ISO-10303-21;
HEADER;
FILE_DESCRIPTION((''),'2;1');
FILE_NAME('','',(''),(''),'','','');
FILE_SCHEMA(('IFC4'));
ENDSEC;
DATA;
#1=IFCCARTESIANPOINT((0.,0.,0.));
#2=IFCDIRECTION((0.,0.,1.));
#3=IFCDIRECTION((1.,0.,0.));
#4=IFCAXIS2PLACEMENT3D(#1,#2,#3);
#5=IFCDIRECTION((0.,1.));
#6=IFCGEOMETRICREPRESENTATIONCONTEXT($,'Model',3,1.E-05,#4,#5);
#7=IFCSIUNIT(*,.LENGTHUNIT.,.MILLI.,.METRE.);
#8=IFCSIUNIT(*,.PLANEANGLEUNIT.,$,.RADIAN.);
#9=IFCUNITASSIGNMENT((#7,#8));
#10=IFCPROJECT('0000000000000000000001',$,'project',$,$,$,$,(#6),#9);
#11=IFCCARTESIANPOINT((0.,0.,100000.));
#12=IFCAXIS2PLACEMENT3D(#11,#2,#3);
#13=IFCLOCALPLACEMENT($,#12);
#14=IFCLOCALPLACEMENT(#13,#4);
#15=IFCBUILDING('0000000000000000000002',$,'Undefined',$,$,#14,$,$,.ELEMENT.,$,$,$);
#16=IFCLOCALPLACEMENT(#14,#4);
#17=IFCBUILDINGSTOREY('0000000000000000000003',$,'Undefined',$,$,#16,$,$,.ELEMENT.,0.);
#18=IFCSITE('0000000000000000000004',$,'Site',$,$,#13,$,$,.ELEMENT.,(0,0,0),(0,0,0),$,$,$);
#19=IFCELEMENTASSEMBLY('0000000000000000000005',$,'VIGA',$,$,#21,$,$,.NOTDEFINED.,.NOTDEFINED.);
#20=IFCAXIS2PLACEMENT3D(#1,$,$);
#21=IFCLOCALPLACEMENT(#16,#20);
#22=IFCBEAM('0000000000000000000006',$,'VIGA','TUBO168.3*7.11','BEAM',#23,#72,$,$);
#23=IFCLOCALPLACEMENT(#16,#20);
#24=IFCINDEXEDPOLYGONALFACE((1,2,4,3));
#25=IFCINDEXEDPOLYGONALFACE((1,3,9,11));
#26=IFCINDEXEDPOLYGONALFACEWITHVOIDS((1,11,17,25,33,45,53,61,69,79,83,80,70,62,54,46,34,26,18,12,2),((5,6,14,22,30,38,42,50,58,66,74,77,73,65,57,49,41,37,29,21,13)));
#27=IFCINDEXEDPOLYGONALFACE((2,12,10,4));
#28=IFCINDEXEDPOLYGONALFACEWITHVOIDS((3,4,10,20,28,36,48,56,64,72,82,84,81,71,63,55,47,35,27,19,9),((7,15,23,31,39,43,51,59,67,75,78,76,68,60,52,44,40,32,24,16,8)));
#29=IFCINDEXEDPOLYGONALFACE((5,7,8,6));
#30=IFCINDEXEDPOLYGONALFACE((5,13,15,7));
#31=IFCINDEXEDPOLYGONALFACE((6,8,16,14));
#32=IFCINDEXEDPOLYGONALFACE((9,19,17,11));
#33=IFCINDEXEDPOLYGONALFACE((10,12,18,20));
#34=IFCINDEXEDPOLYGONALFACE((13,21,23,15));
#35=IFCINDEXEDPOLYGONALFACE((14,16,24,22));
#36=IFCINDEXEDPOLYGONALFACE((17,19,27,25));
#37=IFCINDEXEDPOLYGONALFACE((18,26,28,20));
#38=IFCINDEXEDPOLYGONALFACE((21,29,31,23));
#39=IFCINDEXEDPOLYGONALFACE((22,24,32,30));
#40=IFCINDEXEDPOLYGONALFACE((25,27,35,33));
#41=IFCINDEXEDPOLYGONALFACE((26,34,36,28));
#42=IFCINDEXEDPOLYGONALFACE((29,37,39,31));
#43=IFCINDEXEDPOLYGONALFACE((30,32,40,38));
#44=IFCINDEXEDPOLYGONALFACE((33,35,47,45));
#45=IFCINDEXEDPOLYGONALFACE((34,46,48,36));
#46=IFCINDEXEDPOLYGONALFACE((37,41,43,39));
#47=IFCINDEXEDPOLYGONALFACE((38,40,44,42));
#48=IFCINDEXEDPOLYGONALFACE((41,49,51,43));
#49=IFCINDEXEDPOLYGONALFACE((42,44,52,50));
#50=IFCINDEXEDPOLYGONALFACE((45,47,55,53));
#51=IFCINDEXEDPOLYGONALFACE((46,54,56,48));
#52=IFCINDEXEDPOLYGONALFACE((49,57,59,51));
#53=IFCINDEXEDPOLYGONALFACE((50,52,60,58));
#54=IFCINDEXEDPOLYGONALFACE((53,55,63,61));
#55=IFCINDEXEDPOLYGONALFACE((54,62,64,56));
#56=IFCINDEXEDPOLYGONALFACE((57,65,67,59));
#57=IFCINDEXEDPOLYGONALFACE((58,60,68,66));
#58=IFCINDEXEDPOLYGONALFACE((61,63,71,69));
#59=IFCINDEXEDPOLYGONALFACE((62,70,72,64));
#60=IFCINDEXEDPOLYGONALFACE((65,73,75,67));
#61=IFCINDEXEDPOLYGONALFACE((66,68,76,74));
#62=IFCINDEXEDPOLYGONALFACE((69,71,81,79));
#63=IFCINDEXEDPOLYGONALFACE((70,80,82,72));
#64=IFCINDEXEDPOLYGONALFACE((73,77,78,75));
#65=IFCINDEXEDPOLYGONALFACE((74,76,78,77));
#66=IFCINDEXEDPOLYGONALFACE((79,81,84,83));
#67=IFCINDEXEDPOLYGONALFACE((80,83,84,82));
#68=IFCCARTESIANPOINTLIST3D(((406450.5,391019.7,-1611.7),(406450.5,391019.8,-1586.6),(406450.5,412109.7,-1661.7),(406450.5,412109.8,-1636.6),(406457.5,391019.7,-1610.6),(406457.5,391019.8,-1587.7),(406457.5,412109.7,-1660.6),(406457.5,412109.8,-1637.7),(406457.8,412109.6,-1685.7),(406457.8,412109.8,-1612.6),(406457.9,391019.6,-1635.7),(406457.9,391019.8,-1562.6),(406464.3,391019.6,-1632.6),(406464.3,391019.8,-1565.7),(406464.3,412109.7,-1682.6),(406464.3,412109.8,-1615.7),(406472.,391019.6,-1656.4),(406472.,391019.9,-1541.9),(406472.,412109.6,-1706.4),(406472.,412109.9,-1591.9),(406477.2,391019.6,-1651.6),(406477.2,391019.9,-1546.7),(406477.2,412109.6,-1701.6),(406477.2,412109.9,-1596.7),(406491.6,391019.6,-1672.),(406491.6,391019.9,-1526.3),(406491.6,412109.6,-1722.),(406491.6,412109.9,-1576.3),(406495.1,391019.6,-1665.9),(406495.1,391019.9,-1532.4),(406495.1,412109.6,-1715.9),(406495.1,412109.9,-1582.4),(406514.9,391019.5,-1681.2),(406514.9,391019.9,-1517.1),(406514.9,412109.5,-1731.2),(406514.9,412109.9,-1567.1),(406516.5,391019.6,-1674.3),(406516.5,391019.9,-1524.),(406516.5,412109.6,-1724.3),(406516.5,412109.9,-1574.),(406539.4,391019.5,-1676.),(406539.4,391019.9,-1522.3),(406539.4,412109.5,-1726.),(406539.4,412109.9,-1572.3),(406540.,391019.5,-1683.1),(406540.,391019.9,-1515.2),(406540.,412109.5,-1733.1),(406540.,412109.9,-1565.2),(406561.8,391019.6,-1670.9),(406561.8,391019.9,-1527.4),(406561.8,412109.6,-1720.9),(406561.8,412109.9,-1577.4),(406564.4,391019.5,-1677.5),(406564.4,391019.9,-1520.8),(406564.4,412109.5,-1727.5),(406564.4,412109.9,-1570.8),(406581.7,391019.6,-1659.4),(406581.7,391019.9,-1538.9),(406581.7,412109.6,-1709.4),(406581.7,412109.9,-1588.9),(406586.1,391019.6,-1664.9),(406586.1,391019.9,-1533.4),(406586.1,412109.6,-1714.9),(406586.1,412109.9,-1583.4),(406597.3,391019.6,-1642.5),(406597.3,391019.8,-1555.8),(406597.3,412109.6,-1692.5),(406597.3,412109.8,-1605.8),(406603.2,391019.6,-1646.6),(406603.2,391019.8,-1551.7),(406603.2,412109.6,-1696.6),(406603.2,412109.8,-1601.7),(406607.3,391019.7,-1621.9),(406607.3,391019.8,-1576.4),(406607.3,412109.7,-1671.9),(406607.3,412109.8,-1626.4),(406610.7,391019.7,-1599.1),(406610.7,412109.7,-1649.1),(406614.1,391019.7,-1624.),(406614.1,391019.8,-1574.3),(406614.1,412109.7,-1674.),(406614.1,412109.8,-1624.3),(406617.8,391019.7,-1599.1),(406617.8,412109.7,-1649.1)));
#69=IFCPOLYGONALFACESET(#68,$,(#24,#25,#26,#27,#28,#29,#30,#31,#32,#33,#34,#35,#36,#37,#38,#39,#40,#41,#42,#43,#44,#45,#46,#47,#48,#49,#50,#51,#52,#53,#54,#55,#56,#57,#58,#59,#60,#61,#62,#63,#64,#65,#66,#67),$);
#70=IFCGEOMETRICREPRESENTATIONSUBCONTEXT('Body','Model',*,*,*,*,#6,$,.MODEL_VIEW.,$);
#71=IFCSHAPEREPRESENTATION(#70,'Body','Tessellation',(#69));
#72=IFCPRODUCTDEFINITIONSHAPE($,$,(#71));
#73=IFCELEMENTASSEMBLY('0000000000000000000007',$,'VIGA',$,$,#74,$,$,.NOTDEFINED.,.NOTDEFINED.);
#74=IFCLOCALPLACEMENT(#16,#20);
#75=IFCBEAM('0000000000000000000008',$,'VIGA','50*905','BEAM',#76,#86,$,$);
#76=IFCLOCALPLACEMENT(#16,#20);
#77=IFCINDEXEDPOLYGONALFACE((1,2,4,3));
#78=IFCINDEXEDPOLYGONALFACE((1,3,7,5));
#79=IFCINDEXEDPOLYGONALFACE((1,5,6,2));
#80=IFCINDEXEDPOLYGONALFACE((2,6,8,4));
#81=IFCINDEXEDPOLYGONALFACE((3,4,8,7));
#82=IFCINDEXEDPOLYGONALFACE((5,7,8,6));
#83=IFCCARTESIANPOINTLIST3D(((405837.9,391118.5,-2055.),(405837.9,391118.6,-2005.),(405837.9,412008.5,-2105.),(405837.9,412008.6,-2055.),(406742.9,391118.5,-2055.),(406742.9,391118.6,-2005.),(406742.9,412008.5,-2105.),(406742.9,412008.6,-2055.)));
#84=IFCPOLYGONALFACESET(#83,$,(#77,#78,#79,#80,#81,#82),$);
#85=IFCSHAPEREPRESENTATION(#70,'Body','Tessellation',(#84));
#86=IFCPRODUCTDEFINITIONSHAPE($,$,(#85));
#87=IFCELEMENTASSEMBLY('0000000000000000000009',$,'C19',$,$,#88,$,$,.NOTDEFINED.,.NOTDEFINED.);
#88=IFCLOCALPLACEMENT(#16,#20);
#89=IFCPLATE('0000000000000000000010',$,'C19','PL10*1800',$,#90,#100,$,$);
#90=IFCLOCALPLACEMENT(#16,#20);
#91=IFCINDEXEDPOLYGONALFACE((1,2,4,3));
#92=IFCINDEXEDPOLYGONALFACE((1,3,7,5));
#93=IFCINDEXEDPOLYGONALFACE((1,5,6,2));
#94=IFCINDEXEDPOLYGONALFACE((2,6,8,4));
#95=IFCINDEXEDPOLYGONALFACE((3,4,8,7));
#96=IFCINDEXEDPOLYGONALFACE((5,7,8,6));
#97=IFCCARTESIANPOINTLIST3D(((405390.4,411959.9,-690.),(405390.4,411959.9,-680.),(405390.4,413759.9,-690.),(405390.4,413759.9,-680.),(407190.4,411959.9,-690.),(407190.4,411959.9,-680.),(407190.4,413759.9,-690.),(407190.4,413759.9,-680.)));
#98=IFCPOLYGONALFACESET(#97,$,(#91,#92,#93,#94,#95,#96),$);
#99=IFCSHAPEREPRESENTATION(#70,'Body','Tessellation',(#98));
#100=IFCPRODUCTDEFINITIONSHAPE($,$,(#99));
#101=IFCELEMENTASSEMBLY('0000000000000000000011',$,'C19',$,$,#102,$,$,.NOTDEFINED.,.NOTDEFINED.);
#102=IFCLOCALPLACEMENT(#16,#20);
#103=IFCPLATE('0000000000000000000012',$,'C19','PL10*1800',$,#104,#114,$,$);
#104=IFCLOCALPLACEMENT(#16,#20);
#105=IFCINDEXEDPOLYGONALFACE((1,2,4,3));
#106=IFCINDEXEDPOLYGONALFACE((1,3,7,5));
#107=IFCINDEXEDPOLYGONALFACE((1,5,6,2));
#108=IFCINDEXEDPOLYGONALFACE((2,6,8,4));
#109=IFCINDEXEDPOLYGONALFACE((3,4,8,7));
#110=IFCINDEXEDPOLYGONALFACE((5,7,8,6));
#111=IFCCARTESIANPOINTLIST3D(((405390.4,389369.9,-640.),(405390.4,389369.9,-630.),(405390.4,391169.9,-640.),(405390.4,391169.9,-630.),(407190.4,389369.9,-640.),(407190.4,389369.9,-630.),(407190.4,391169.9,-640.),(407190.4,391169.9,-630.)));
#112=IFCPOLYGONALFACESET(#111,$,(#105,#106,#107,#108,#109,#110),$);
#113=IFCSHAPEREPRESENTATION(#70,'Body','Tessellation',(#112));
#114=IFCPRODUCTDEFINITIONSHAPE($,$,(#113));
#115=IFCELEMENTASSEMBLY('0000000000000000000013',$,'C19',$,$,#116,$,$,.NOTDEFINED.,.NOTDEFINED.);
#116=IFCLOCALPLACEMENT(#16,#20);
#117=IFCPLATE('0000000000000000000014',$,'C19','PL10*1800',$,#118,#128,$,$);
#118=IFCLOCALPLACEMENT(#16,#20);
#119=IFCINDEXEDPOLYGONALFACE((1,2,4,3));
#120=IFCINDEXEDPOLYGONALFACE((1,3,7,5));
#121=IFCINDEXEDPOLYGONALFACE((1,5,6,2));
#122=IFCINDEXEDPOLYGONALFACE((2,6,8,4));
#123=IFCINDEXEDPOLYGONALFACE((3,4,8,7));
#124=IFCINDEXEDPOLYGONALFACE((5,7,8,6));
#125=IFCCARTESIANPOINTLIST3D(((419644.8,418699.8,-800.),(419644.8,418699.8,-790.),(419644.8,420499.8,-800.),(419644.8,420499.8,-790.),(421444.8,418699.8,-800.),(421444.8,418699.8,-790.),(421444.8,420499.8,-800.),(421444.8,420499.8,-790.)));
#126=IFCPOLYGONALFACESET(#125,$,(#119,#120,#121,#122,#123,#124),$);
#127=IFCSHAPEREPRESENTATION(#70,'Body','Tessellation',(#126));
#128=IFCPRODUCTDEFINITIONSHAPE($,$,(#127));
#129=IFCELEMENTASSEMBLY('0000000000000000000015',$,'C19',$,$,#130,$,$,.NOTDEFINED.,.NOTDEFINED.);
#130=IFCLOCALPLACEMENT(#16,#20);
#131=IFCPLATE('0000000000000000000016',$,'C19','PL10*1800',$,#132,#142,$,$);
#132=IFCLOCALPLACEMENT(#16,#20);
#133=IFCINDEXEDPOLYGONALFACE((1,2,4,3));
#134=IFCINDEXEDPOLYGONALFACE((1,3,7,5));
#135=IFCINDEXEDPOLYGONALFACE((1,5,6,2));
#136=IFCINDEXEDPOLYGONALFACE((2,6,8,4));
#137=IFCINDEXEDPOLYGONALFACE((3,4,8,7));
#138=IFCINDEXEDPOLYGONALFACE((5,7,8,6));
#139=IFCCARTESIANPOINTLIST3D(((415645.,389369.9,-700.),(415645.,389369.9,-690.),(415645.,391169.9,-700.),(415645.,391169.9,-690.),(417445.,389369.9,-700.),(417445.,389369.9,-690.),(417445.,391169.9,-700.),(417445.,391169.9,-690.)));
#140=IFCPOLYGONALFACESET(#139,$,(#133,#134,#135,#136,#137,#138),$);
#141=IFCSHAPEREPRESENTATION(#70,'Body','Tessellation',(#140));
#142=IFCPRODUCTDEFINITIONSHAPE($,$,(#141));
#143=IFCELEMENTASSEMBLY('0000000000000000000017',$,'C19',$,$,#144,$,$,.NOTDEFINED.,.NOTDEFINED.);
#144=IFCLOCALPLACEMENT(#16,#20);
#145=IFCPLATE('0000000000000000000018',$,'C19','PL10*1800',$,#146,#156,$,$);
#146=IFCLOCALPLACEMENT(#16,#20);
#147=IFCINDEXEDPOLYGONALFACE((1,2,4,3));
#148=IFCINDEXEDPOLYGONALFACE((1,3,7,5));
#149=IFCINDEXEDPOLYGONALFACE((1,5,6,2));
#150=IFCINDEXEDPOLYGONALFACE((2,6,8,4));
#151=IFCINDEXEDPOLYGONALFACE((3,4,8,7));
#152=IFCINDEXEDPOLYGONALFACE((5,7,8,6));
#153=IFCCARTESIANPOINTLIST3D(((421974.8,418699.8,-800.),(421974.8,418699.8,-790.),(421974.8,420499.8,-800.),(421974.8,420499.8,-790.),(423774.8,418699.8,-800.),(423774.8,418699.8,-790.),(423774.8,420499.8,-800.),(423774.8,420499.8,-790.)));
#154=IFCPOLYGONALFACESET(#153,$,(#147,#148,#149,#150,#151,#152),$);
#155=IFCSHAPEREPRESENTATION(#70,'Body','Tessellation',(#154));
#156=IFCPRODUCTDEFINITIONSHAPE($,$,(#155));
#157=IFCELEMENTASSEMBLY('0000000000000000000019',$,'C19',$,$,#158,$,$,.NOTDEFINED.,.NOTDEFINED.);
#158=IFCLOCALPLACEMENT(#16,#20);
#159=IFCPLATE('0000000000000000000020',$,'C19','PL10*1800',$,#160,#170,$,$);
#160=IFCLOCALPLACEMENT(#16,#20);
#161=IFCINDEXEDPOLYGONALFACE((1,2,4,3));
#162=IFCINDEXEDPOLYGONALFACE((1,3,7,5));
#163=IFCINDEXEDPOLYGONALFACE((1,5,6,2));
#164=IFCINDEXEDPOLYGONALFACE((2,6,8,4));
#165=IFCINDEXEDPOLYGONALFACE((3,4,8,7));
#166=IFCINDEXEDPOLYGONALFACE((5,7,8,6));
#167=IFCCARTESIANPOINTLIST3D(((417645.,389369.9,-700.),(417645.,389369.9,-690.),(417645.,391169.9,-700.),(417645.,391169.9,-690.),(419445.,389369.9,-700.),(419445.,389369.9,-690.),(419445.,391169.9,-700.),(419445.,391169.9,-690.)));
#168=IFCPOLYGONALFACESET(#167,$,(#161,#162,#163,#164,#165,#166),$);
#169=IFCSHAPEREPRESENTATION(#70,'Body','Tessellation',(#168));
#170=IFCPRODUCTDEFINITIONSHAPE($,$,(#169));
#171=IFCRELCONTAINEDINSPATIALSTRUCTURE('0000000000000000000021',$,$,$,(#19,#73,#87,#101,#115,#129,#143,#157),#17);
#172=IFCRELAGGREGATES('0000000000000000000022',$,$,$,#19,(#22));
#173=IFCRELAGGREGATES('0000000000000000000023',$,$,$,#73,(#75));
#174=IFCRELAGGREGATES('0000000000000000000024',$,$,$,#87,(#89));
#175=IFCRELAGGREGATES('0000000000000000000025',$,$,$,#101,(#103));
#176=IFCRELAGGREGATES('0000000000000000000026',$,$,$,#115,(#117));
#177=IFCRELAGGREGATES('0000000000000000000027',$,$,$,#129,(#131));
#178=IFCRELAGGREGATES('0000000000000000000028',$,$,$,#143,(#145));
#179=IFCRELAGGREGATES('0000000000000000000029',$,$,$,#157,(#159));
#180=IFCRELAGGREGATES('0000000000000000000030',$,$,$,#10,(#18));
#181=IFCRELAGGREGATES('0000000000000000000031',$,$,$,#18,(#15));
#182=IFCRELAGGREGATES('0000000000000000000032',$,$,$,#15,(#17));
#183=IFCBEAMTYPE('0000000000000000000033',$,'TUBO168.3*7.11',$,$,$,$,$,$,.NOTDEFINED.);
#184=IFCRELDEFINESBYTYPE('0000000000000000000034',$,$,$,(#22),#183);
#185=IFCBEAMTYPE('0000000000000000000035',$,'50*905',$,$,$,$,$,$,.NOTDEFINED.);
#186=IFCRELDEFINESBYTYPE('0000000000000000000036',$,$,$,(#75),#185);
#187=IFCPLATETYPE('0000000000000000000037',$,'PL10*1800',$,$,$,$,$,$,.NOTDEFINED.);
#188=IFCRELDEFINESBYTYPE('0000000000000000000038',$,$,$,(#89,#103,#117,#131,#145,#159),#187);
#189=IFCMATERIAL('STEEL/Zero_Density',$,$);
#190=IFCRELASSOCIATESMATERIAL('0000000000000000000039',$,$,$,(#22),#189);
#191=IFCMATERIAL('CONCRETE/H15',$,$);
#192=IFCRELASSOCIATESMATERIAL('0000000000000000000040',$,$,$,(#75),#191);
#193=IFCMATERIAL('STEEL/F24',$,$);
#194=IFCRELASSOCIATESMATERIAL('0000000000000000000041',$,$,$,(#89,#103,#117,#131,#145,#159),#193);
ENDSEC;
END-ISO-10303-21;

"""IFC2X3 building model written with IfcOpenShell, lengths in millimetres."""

from ifc_helpers import new_model, si_unit, direction, frame, origin_with_axes, origin_2d_with_axis, place, context, subcontext, project, spatial, polyline, rectangle, hollow_circle, outline, extrude, material, type_object, element, aggregate, save


model = new_model("IFC2X3")

# Units and contexts
model_context = context("Model", 3, precision=1e-05, world=origin_with_axes(), true_north=direction((0.0, 1.0)))
body_context = subcontext(model_context, "Body", "Model", "MODEL_VIEW")
ifc_project = project(units=[si_unit("LENGTHUNIT", "METRE", prefix="MILLI"), si_unit("PLANEANGLEUNIT", "RADIAN")], contexts=[model_context])

# Site, building, storey
site_placement = place(None, frame((0.0, 0.0, 100000.0), z_axis=(0.0, 0.0, 1.0), x_axis=(1.0, 0.0, 0.0)))
site = spatial("IfcSite", under=ifc_project, at=site_placement, Name="Site", CompositionType="ELEMENT", RefLatitude=(0, 0, 0), RefLongitude=(0, 0, 0))
building_placement = place(site_placement, origin_with_axes())
building = spatial("IfcBuilding", under=site, at=building_placement, Name="Undefined", CompositionType="ELEMENT")
storey_placement = place(building_placement, origin_with_axes())
storey = spatial("IfcBuildingStorey", under=building, at=storey_placement, Name="Undefined", CompositionType="ELEMENT", Elevation=0.0)

# Element assemblies, beams
ifc_material_1 = material(Name="CONCRETE/H15")
ifc_material_2 = material(Name="STEEL/F24")
beam_type_1 = type_object("IfcBeamType", Name="TUBO168.3*7.11", PredefinedType="NOTDEFINED")
ifc_material_3 = material(Name="STEEL/Zero_Density")
assembly_1_placement = place(storey_placement, origin_with_axes())
assembly_1 = element("IfcElementAssembly", 1, at=assembly_1_placement, inside=storey, Name="VIGA", AssemblyPlace="NOTDEFINED", PredefinedType="NOTDEFINED")
beam_1_placement = place(assembly_1_placement, frame((406533.7, 391019.7, -1599.1), z_axis=(0.0, 0.002371, 0.999997), x_axis=(0.0, 0.999997, -0.002371)))
beam_1 = element("IfcBeam", 2, at=beam_1_placement, type_object=beam_type_1, material=ifc_material_3, Name="VIGA", Description="TUBO168.3*7.11", ObjectType="BEAM", context=body_context, shape_type="SweptSolid", body=[
    extrude(hollow_circle(Radius=84.2, WallThickness=7.1, at=origin_2d_with_axis()), frame((21090.1, 0.0, 0.0), z_axis=(-1.0, 0.0, 0.0), x_axis=(0.0, -1.0, 0.0)), (0.0, 0.0, 1.0), 21090.1),
])
aggregate(assembly_1, [beam_1])
assembly_2_placement = place(storey_placement, origin_with_axes())
assembly_2 = element("IfcElementAssembly", 3, at=assembly_2_placement, inside=storey, Name="VIGA", AssemblyPlace="NOTDEFINED", PredefinedType="NOTDEFINED")
beam_type_2 = type_object("IfcBeamType", Name="50*905", PredefinedType="NOTDEFINED")
beam_2_placement = place(assembly_2_placement, frame((406290.4, 391118.5, -2030.0), z_axis=(0.0, 0.002393, 0.999997), x_axis=(0.0, 0.999997, -0.002393)))
beam_2 = element("IfcBeam", 4, at=beam_2_placement, type_object=beam_type_2, material=ifc_material_1, Name="VIGA", Description="50*905", ObjectType="BEAM", context=body_context, shape_type="SweptSolid", body=[
    extrude(rectangle(XDim=905.0, YDim=50.0, at=origin_2d_with_axis()), frame((20890.1, 0.0, 0.0), z_axis=(-1.0, 0.0, 0.0), x_axis=(0.0, -1.0, 0.0)), (0.0, 0.0, 1.0), 20890.1),
])
aggregate(assembly_2, [beam_2])

# Element assemblies, plates
assembly_3_placement = place(storey_placement, origin_with_axes())
assembly_3 = element("IfcElementAssembly", 5, at=assembly_3_placement, inside=storey, Name="C19", AssemblyPlace="NOTDEFINED", PredefinedType="NOTDEFINED")
plate_type = type_object("IfcPlateType", Name="PL10*1800", PredefinedType="NOTDEFINED")
plate_1_placement = place(assembly_3_placement, frame((405390.4, 411959.9, -685.0), z_axis=(0.0, 0.0, 1.0), x_axis=(1.0, 0.0, 0.0)))
plate_1 = element("IfcPlate", 6, at=plate_1_placement, type_object=plate_type, material=ifc_material_2, Name="C19", Description="PL10*1800", context=body_context, shape_type="SweptSolid", body=[
    extrude(outline(polyline([(0.0, 0.0), (1800.0, 0.0), (1800.0, 1800.0), (0.0, 1800.0), (0.0, 0.0)])), frame((0.0, 0.0, -5.0), z_axis=(0.0, 0.0, 1.0), x_axis=(1.0, 0.0, 0.0)), (0.0, 0.0, 1.0), 10.0),
])
aggregate(assembly_3, [plate_1])
assembly_4_placement = place(storey_placement, origin_with_axes())
assembly_4 = element("IfcElementAssembly", 7, at=assembly_4_placement, inside=storey, Name="C19", AssemblyPlace="NOTDEFINED", PredefinedType="NOTDEFINED")
plate_2_placement = place(assembly_4_placement, frame((405390.4, 389369.9, -635.0), z_axis=(0.0, 0.0, 1.0), x_axis=(1.0, 0.0, 0.0)))
plate_2 = element("IfcPlate", 8, at=plate_2_placement, type_object=plate_type, material=ifc_material_2, Name="C19", Description="PL10*1800", context=body_context, shape_type="SweptSolid", body=[
    extrude(outline(polyline([(0.0, 0.0), (1800.0, 0.0), (1800.0, 1800.0), (0.0, 1800.0), (0.0, 0.0)])), frame((0.0, 0.0, -5.0), z_axis=(0.0, 0.0, 1.0), x_axis=(1.0, 0.0, 0.0)), (0.0, 0.0, 1.0), 10.0),
])
aggregate(assembly_4, [plate_2])
assembly_5_placement = place(storey_placement, origin_with_axes())
assembly_5 = element("IfcElementAssembly", 9, at=assembly_5_placement, inside=storey, Name="C19", AssemblyPlace="NOTDEFINED", PredefinedType="NOTDEFINED")
plate_3_placement = place(assembly_5_placement, frame((419644.8, 418699.8, -795.0), z_axis=(0.0, 0.0, 1.0), x_axis=(1.0, 0.0, 0.0)))
plate_3 = element("IfcPlate", 10, at=plate_3_placement, type_object=plate_type, material=ifc_material_2, Name="C19", Description="PL10*1800", context=body_context, shape_type="SweptSolid", body=[
    extrude(outline(polyline([(0.0, 0.0), (1800.0, 0.0), (1800.0, 1800.0), (0.0, 1800.0), (0.0, 0.0)])), frame((0.0, 0.0, -5.0), z_axis=(0.0, 0.0, 1.0), x_axis=(1.0, 0.0, 0.0)), (0.0, 0.0, 1.0), 10.0),
])
aggregate(assembly_5, [plate_3])
assembly_6_placement = place(storey_placement, origin_with_axes())
assembly_6 = element("IfcElementAssembly", 11, at=assembly_6_placement, inside=storey, Name="C19", AssemblyPlace="NOTDEFINED", PredefinedType="NOTDEFINED")
plate_4_placement = place(assembly_6_placement, frame((415645.0, 389369.9, -695.0), z_axis=(0.0, 0.0, 1.0), x_axis=(1.0, 0.0, 0.0)))
plate_4 = element("IfcPlate", 12, at=plate_4_placement, type_object=plate_type, material=ifc_material_2, Name="C19", Description="PL10*1800", context=body_context, shape_type="SweptSolid", body=[
    extrude(outline(polyline([(0.0, 0.0), (1800.0, 0.0), (1800.0, 1800.0), (0.0, 1800.0), (0.0, 0.0)])), frame((0.0, 0.0, -5.0), z_axis=(0.0, 0.0, 1.0), x_axis=(1.0, 0.0, 0.0)), (0.0, 0.0, 1.0), 10.0),
])
aggregate(assembly_6, [plate_4])
assembly_7_placement = place(storey_placement, origin_with_axes())
assembly_7 = element("IfcElementAssembly", 13, at=assembly_7_placement, inside=storey, Name="C19", AssemblyPlace="NOTDEFINED", PredefinedType="NOTDEFINED")
plate_5_placement = place(assembly_7_placement, frame((421974.8, 418699.8, -795.0), z_axis=(0.0, 0.0, 1.0), x_axis=(1.0, 0.0, 0.0)))
plate_5 = element("IfcPlate", 14, at=plate_5_placement, type_object=plate_type, material=ifc_material_2, Name="C19", Description="PL10*1800", context=body_context, shape_type="SweptSolid", body=[
    extrude(outline(polyline([(0.0, 0.0), (1800.0, 0.0), (1800.0, 1800.0), (0.0, 1800.0), (0.0, 0.0)])), frame((0.0, 0.0, -5.0), z_axis=(0.0, 0.0, 1.0), x_axis=(1.0, 0.0, 0.0)), (0.0, 0.0, 1.0), 10.0),
])
aggregate(assembly_7, [plate_5])
assembly_8_placement = place(storey_placement, origin_with_axes())
assembly_8 = element("IfcElementAssembly", 15, at=assembly_8_placement, inside=storey, Name="C19", AssemblyPlace="NOTDEFINED", PredefinedType="NOTDEFINED")
plate_6_placement = place(assembly_8_placement, frame((417645.0, 389369.9, -695.0), z_axis=(0.0, 0.0, 1.0), x_axis=(1.0, 0.0, 0.0)))
plate_6 = element("IfcPlate", 16, at=plate_6_placement, type_object=plate_type, material=ifc_material_2, Name="C19", Description="PL10*1800", context=body_context, shape_type="SweptSolid", body=[
    extrude(outline(polyline([(0.0, 0.0), (1800.0, 0.0), (1800.0, 1800.0), (0.0, 1800.0), (0.0, 0.0)])), frame((0.0, 0.0, -5.0), z_axis=(0.0, 0.0, 1.0), x_axis=(1.0, 0.0, 0.0)), (0.0, 0.0, 1.0), 10.0),
])
aggregate(assembly_8, [plate_6])

save(model, "model.ifc")
